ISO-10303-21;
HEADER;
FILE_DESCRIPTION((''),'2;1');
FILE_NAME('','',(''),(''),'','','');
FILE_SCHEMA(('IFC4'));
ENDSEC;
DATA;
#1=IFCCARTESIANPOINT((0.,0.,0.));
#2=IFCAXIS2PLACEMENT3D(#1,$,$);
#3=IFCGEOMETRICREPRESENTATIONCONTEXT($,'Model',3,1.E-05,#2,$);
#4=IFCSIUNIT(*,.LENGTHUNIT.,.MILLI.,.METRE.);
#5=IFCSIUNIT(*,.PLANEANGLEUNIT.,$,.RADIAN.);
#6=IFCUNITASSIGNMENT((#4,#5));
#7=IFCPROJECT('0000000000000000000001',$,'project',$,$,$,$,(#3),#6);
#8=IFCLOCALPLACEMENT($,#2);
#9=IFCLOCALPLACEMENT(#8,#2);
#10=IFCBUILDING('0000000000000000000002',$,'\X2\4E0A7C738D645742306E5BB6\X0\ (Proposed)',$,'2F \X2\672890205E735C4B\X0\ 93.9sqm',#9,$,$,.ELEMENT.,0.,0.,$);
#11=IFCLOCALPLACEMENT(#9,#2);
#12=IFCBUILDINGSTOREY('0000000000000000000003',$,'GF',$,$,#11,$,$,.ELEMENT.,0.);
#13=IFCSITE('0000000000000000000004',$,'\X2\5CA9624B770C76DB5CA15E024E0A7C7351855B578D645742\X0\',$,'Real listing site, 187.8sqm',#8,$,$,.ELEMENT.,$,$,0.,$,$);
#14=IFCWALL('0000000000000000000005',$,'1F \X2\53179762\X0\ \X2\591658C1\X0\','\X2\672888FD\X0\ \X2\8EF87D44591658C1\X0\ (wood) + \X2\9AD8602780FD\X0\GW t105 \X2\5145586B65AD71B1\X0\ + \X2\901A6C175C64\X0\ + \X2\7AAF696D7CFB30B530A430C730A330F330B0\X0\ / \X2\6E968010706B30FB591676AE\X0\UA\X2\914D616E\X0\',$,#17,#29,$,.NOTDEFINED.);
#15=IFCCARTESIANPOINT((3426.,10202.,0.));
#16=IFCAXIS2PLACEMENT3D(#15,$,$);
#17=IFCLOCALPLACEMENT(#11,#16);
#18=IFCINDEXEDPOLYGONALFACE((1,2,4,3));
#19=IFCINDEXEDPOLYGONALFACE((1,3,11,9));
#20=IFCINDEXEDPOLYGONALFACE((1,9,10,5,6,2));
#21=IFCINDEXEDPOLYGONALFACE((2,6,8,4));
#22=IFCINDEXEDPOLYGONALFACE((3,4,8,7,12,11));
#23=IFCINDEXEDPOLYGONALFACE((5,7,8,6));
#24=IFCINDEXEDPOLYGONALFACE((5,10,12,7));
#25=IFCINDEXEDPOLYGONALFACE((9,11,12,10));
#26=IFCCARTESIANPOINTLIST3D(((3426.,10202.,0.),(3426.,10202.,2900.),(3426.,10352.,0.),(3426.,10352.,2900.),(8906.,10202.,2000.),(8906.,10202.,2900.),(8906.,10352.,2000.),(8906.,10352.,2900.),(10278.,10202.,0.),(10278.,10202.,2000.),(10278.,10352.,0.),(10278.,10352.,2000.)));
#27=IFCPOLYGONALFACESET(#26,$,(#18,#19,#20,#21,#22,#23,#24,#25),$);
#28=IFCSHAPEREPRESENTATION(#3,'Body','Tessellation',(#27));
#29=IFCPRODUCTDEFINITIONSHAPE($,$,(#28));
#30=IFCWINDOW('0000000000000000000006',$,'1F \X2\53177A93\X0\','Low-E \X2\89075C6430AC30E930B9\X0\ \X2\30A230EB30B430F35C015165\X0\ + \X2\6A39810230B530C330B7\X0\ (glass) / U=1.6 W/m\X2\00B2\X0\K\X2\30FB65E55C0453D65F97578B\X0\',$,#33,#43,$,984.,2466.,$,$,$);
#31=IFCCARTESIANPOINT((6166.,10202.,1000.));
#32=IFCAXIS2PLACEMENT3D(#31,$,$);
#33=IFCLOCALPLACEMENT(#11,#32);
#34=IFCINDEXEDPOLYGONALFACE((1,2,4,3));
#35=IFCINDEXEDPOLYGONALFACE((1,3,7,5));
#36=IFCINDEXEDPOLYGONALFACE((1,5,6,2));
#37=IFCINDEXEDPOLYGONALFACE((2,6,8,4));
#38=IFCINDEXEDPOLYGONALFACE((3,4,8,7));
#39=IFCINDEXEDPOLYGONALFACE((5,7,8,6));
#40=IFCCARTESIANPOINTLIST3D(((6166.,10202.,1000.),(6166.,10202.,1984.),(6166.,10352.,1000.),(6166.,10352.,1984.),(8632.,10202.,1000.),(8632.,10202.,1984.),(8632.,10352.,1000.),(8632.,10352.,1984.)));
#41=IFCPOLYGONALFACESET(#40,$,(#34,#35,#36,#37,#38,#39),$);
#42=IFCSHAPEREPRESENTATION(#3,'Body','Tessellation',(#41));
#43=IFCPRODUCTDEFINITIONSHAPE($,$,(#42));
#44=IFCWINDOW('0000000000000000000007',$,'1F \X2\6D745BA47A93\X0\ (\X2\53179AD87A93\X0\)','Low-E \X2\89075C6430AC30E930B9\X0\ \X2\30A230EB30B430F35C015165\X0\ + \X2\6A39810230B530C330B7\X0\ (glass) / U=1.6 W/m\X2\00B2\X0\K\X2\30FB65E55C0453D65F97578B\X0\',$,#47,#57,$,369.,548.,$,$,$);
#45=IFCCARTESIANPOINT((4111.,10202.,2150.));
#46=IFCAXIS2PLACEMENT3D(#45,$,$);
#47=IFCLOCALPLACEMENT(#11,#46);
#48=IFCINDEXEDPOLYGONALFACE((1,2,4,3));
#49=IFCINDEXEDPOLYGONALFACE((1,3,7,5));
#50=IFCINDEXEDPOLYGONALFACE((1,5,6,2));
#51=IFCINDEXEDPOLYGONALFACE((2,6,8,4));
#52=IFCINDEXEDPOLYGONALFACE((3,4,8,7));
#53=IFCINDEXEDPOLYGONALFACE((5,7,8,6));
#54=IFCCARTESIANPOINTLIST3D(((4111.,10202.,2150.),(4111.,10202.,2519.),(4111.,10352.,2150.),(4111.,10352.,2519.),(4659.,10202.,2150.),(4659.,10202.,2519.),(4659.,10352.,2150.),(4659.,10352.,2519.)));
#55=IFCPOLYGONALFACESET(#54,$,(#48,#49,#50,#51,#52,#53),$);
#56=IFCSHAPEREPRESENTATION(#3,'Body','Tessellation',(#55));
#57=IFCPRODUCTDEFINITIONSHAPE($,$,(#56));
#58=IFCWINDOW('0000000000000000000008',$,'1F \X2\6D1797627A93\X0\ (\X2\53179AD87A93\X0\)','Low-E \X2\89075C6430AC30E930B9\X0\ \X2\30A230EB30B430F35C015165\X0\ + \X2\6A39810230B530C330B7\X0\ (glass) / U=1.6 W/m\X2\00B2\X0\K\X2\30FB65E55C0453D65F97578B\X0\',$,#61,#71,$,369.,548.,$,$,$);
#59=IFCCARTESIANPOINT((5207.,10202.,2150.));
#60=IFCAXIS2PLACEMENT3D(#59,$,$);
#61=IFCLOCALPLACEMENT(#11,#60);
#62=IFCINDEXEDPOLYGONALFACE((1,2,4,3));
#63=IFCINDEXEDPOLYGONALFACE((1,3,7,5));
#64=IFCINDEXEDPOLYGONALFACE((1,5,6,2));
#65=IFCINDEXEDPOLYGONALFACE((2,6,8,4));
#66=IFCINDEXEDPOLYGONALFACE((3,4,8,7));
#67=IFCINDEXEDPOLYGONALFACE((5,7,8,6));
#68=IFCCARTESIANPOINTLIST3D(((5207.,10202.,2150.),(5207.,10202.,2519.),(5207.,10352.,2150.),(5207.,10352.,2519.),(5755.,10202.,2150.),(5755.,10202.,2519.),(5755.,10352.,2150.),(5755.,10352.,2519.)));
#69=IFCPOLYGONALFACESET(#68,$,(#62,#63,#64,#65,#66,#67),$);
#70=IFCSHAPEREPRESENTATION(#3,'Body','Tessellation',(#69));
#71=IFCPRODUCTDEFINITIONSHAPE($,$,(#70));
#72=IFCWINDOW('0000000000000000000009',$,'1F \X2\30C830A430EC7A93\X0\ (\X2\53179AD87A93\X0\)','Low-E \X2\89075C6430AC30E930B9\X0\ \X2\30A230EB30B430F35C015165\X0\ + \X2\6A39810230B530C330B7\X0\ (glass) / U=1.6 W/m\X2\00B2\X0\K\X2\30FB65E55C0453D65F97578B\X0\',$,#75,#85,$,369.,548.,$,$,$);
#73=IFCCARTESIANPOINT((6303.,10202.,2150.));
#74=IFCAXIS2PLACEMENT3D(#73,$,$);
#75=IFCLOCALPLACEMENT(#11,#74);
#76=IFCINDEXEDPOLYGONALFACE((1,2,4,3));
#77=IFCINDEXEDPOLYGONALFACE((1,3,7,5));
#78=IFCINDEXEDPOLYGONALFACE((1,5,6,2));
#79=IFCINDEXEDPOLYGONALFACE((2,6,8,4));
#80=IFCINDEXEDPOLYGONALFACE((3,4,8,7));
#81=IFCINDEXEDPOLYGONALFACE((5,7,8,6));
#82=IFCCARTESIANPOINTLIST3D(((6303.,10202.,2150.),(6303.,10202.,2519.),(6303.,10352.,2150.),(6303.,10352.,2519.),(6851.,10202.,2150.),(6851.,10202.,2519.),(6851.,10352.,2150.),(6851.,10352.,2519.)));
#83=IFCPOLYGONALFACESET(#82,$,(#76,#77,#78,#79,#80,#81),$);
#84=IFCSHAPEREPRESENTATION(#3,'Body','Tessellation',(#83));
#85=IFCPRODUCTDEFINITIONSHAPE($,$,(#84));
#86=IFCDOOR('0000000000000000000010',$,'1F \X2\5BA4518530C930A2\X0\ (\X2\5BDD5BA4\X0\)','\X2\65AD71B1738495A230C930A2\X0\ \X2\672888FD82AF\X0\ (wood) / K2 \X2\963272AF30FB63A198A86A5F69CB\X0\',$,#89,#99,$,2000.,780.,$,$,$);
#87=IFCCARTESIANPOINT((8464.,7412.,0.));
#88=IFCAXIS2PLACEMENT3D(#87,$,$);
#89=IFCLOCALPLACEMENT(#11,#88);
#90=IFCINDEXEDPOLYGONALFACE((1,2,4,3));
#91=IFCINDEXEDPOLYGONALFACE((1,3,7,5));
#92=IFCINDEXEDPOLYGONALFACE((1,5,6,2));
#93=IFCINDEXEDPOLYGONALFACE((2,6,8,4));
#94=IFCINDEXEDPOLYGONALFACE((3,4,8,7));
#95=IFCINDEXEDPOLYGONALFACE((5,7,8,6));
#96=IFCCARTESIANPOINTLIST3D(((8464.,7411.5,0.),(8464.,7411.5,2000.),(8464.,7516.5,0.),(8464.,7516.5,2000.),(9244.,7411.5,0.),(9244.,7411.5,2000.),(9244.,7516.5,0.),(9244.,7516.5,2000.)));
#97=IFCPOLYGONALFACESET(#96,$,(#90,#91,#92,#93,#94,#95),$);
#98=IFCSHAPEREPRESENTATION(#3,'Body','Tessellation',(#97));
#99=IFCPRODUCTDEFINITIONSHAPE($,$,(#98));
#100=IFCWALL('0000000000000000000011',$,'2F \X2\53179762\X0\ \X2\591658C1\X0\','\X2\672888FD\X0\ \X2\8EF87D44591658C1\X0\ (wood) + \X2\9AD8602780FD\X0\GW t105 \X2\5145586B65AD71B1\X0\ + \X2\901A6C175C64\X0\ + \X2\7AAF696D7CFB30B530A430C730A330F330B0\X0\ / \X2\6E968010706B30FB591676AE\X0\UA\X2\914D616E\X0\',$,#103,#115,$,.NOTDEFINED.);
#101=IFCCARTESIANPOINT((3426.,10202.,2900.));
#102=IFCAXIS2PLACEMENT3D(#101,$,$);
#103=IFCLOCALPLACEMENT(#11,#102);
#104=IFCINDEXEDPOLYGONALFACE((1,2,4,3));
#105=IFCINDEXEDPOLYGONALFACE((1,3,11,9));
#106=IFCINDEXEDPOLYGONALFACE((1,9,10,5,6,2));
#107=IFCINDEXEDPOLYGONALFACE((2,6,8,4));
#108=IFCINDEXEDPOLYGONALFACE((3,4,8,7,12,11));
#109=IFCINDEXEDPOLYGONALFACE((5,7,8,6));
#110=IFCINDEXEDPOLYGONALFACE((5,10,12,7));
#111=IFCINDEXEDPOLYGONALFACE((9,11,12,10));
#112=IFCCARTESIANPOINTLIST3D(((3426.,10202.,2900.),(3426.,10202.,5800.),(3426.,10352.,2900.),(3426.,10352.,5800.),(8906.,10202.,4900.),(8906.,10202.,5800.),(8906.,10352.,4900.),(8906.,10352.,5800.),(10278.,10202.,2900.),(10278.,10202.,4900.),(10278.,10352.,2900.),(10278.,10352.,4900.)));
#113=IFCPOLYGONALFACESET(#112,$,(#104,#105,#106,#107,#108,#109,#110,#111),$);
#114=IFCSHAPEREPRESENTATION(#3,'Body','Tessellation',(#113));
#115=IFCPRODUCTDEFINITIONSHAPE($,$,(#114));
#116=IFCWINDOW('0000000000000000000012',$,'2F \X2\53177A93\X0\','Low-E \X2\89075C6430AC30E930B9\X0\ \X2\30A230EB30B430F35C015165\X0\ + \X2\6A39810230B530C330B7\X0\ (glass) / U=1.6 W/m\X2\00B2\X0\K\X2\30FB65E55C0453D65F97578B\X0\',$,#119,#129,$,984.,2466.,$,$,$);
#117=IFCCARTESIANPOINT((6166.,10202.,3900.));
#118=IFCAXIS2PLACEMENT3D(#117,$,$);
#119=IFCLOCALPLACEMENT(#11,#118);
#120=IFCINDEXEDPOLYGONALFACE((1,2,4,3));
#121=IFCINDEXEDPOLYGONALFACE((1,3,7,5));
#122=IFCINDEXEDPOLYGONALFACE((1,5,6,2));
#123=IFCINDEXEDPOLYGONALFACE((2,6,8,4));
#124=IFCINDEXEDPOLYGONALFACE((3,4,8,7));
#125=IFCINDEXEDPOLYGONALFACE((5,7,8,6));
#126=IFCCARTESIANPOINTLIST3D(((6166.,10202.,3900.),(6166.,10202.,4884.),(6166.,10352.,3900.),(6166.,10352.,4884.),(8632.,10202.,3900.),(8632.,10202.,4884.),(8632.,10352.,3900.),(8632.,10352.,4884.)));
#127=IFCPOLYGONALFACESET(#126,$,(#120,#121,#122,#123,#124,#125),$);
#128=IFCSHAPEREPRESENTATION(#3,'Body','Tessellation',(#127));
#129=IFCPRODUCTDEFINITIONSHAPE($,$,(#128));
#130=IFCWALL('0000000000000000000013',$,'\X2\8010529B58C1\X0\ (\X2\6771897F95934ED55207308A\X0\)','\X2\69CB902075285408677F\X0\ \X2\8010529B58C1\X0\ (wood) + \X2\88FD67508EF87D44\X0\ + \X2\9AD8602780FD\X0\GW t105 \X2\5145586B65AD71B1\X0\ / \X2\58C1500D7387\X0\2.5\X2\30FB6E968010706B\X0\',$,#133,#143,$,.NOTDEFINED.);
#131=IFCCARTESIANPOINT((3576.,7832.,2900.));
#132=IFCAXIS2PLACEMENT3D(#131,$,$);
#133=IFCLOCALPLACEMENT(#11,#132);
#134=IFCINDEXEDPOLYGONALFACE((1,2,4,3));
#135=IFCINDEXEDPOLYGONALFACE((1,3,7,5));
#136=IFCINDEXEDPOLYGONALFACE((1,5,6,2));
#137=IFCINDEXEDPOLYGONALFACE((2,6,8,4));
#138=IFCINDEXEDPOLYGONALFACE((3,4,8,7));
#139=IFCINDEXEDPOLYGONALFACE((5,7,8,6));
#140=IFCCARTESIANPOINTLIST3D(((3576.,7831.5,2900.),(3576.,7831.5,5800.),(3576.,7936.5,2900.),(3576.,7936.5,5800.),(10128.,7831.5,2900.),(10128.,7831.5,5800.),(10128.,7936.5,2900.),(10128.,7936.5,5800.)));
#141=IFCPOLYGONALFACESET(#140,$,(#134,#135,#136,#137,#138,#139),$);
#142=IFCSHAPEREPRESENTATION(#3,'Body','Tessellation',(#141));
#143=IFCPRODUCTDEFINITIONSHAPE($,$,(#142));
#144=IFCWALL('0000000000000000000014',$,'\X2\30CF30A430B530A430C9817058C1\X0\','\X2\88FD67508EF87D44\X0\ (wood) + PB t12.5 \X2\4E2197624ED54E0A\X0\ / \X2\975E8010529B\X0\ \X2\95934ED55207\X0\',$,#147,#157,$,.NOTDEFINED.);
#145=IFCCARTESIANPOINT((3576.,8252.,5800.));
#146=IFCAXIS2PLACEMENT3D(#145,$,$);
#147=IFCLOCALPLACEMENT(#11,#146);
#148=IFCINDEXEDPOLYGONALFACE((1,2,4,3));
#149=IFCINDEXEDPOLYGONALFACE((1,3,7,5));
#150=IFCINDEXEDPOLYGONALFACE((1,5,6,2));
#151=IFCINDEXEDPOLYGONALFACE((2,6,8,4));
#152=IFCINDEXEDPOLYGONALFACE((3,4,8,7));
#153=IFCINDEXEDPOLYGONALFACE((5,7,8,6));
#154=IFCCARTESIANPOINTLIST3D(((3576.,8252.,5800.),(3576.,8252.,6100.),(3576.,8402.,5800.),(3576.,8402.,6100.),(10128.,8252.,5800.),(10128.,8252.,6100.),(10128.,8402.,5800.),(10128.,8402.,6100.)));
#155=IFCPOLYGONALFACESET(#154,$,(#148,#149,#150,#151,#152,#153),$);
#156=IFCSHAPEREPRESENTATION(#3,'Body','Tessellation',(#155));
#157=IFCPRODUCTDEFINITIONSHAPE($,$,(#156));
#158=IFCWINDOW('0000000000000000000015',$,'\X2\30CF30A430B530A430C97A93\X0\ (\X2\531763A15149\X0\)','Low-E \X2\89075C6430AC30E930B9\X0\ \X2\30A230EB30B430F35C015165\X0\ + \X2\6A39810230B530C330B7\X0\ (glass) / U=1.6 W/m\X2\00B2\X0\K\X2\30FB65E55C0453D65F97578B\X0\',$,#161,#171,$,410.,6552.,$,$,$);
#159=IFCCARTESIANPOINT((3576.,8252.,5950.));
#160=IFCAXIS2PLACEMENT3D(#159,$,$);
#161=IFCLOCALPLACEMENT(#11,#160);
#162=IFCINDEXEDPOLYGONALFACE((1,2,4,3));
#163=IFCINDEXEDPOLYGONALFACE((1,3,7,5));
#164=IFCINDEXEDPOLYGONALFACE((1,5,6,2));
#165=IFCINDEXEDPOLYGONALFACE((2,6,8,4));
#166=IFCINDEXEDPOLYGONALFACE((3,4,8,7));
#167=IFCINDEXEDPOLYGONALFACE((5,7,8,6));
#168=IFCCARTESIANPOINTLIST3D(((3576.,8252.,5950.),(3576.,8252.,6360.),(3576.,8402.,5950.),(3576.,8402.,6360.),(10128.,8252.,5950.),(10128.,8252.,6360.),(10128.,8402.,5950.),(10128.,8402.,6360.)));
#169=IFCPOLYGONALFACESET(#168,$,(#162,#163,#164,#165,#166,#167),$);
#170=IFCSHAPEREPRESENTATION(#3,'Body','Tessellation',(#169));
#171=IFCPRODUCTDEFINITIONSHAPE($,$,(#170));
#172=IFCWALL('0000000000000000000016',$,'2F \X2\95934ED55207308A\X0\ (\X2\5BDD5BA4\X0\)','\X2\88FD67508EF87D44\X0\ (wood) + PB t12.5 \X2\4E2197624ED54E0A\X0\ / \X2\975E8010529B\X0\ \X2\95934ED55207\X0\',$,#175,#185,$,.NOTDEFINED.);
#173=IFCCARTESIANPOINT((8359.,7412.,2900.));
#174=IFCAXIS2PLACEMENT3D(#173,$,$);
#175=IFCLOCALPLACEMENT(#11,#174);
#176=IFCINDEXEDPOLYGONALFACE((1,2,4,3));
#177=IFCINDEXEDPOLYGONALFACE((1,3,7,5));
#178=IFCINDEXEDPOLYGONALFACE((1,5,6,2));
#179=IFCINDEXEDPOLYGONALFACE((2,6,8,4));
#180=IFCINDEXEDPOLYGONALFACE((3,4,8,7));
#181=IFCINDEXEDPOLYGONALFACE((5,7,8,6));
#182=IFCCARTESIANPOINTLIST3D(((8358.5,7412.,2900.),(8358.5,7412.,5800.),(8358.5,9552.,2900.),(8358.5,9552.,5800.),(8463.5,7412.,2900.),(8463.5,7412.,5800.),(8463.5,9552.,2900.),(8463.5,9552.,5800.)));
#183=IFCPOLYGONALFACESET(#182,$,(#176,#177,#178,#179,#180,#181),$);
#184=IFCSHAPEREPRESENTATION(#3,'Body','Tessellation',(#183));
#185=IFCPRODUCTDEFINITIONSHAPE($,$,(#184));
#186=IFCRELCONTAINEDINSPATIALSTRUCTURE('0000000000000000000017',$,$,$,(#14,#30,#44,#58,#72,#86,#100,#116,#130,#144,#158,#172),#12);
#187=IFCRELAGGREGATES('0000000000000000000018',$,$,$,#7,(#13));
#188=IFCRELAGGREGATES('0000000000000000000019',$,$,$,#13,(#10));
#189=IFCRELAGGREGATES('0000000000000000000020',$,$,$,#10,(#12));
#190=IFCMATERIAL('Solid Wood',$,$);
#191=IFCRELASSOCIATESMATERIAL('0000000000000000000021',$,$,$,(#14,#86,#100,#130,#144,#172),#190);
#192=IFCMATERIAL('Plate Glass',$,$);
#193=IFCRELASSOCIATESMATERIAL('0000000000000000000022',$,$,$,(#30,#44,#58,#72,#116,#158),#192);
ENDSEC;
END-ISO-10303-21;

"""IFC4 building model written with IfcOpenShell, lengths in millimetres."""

from ifc_helpers import new_model, si_unit, frame, frame_2d, origin, place, context, project, spatial, rectangle, extrude, material, element, fill, save


model = new_model("IFC4")

# Units and contexts
model_context = context("Model", 3, precision=1e-05, world=origin())
ifc_project = project(units=[si_unit("LENGTHUNIT", "METRE", prefix="MILLI"), si_unit("PLANEANGLEUNIT", "RADIAN")], contexts=[model_context])

# Site, building, storey
site_placement = place(None, origin())
site = spatial("IfcSite", under=ifc_project, at=site_placement, Name="岩手県盛岡市上米内字赤坂", ObjectType="Real listing site, 187.8sqm", CompositionType="ELEMENT", RefElevation=0.0)
building_placement = place(site_placement, origin())
building = spatial("IfcBuilding", under=site, at=building_placement, Name="上米赤坂の家 (Proposed)", ObjectType="2F 木造平屋 93.9sqm", CompositionType="ELEMENT", ElevationOfRefHeight=0.0, ElevationOfTerrain=0.0)
storey_placement = place(building_placement, origin())
storey = spatial("IfcBuildingStorey", under=building, at=storey_placement, Name="GF", CompositionType="ELEMENT", Elevation=0.0)

# Wall, openings, windows
ifc_material_1 = material(Name="Solid Wood")
wall_1_placement = place(storey_placement, frame((3426.0, 10202.0, 0.0)))
wall_1 = element("IfcWall", 1, at=wall_1_placement, inside=storey, material=ifc_material_1, Name="1F 北面 外壁", Description="木製 軸組外壁 (wood) + 高性能GW t105 充填断熱 + 通気層 + 窯業系サイディング / 準耐火・外皮UA配慮", PredefinedType="NOTDEFINED", context=model_context, shape_type="SweptSolid", body=[
    extrude(rectangle(XDim=6852.0, YDim=150.0, at=frame_2d((3426.0, 75.0))), frame((3426.0, 10202.0, 0.0)), (0.0, 0.0, 1.0), 2900.0),
])
opening_1_placement = place(storey_placement, frame((6166.0, 10202.0, 1000.0)))
opening_1 = element("IfcOpeningElement", 2, at=opening_1_placement, cuts=wall_1, PredefinedType="NOTDEFINED", context=model_context, shape_type="SweptSolid", body=[
    extrude(rectangle(XDim=2466.0, YDim=150.0, at=frame_2d((1233.0, 75.0))), frame((6166.0, 10202.0, 1000.0)), (0.0, 0.0, 1.0), 984.0),
])
opening_2_placement = place(storey_placement, frame((4111.0, 10202.0, 2150.0)))
opening_2 = element("IfcOpeningElement", 3, at=opening_2_placement, cuts=wall_1, PredefinedType="NOTDEFINED", context=model_context, shape_type="SweptSolid", body=[
    extrude(rectangle(XDim=548.0, YDim=150.0, at=frame_2d((274.0, 75.0))), frame((4111.0, 10202.0, 2150.0)), (0.0, 0.0, 1.0), 369.0),
])
opening_3_placement = place(storey_placement, frame((5207.0, 10202.0, 2150.0)))
opening_3 = element("IfcOpeningElement", 4, at=opening_3_placement, cuts=wall_1, PredefinedType="NOTDEFINED", context=model_context, shape_type="SweptSolid", body=[
    extrude(rectangle(XDim=548.0, YDim=150.0, at=frame_2d((274.0, 75.0))), frame((5207.0, 10202.0, 2150.0)), (0.0, 0.0, 1.0), 369.0),
])
opening_4_placement = place(storey_placement, frame((6303.0, 10202.0, 2150.0)))
opening_4 = element("IfcOpeningElement", 5, at=opening_4_placement, cuts=wall_1, PredefinedType="NOTDEFINED", context=model_context, shape_type="SweptSolid", body=[
    extrude(rectangle(XDim=548.0, YDim=150.0, at=frame_2d((274.0, 75.0))), frame((6303.0, 10202.0, 2150.0)), (0.0, 0.0, 1.0), 369.0),
])
ifc_material_2 = material(Name="Plate Glass")
window_1_placement = place(storey_placement, frame((6166.0, 10202.0, 1000.0)))
window_1 = element("IfcWindow", 6, at=window_1_placement, inside=storey, material=ifc_material_2, Name="1F 北窓", Description="Low-E 複層ガラス アルゴン封入 + 樹脂サッシ (glass) / U=1.6 W/m²K・日射取得型", OverallHeight=984.0, OverallWidth=2466.0, context=model_context, shape_type="SweptSolid", body=[
    extrude(rectangle(XDim=2466.0, YDim=150.0, at=frame_2d((1233.0, 75.0))), frame((6166.0, 10202.0, 1000.0)), (0.0, 0.0, 1.0), 984.0),
])
fill(opening_1, window_1)
window_2_placement = place(storey_placement, frame((4111.0, 10202.0, 2150.0)))
window_2 = element("IfcWindow", 7, at=window_2_placement, inside=storey, material=ifc_material_2, Name="1F 浴室窓 (北高窓)", Description="Low-E 複層ガラス アルゴン封入 + 樹脂サッシ (glass) / U=1.6 W/m²K・日射取得型", OverallHeight=369.0, OverallWidth=548.0, context=model_context, shape_type="SweptSolid", body=[
    extrude(rectangle(XDim=548.0, YDim=150.0, at=frame_2d((274.0, 75.0))), frame((4111.0, 10202.0, 2150.0)), (0.0, 0.0, 1.0), 369.0),
])
fill(opening_2, window_2)
window_3_placement = place(storey_placement, frame((5207.0, 10202.0, 2150.0)))
window_3 = element("IfcWindow", 8, at=window_3_placement, inside=storey, material=ifc_material_2, Name="1F 洗面窓 (北高窓)", Description="Low-E 複層ガラス アルゴン封入 + 樹脂サッシ (glass) / U=1.6 W/m²K・日射取得型", OverallHeight=369.0, OverallWidth=548.0, context=model_context, shape_type="SweptSolid", body=[
    extrude(rectangle(XDim=548.0, YDim=150.0, at=frame_2d((274.0, 75.0))), frame((5207.0, 10202.0, 2150.0)), (0.0, 0.0, 1.0), 369.0),
])
fill(opening_3, window_3)
window_4_placement = place(storey_placement, frame((6303.0, 10202.0, 2150.0)))
window_4 = element("IfcWindow", 9, at=window_4_placement, inside=storey, material=ifc_material_2, Name="1F トイレ窓 (北高窓)", Description="Low-E 複層ガラス アルゴン封入 + 樹脂サッシ (glass) / U=1.6 W/m²K・日射取得型", OverallHeight=369.0, OverallWidth=548.0, context=model_context, shape_type="SweptSolid", body=[
    extrude(rectangle(XDim=548.0, YDim=150.0, at=frame_2d((274.0, 75.0))), frame((6303.0, 10202.0, 2150.0)), (0.0, 0.0, 1.0), 369.0),
])
fill(opening_4, window_4)

# Door
door_1_placement = place(storey_placement, frame((8464.0, 7412.0, 0.0)))
element("IfcDoor", 10, at=door_1_placement, inside=storey, material=ifc_material_1, Name="1F 室内ドア (寝室)", Description="断熱玄関ドア 木製芯 (wood) / K2 防犯・採風機構", OverallHeight=2000.0, OverallWidth=780.0, context=model_context, shape_type="SweptSolid", body=[
    extrude(rectangle(XDim=780.0, YDim=105.0, at=frame_2d((390.0, 52.0))), frame((8464.0, 7412.0, 0.0)), (0.0, 0.0, 1.0), 2000.0),
])

# Wall, opening, window
wall_2_placement = place(storey_placement, frame((3426.0, 10202.0, 2900.0)))
wall_2 = element("IfcWall", 11, at=wall_2_placement, inside=storey, material=ifc_material_1, Name="2F 北面 外壁", Description="木製 軸組外壁 (wood) + 高性能GW t105 充填断熱 + 通気層 + 窯業系サイディング / 準耐火・外皮UA配慮", PredefinedType="NOTDEFINED", context=model_context, shape_type="SweptSolid", body=[
    extrude(rectangle(XDim=6852.0, YDim=150.0, at=frame_2d((3426.0, 75.0))), frame((3426.0, 10202.0, 2900.0)), (0.0, 0.0, 1.0), 2900.0),
])
opening_5_placement = place(storey_placement, frame((6166.0, 10202.0, 3900.0)))
opening_5 = element("IfcOpeningElement", 12, at=opening_5_placement, cuts=wall_2, PredefinedType="NOTDEFINED", context=model_context, shape_type="SweptSolid", body=[
    extrude(rectangle(XDim=2466.0, YDim=150.0, at=frame_2d((1233.0, 75.0))), frame((6166.0, 10202.0, 3900.0)), (0.0, 0.0, 1.0), 984.0),
])
window_5_placement = place(storey_placement, frame((6166.0, 10202.0, 3900.0)))
window_5 = element("IfcWindow", 13, at=window_5_placement, inside=storey, material=ifc_material_2, Name="2F 北窓", Description="Low-E 複層ガラス アルゴン封入 + 樹脂サッシ (glass) / U=1.6 W/m²K・日射取得型", OverallHeight=984.0, OverallWidth=2466.0, context=model_context, shape_type="SweptSolid", body=[
    extrude(rectangle(XDim=2466.0, YDim=150.0, at=frame_2d((1233.0, 75.0))), frame((6166.0, 10202.0, 3900.0)), (0.0, 0.0, 1.0), 984.0),
])
fill(opening_5, window_5)

# Wall
wall_3_placement = place(storey_placement, frame((3576.0, 7832.0, 2900.0)))
element("IfcWall", 14, at=wall_3_placement, inside=storey, material=ifc_material_1, Name="耐力壁 (東西間仕切り)", Description="構造用合板 耐力壁 (wood) + 製材軸組 + 高性能GW t105 充填断熱 / 壁倍率2.5・準耐火", PredefinedType="NOTDEFINED", context=model_context, shape_type="SweptSolid", body=[
    extrude(rectangle(XDim=6552.0, YDim=105.0, at=frame_2d((3276.0, 52.0))), frame((3576.0, 7832.0, 2900.0)), (0.0, 0.0, 1.0), 2900.0),
])

# Wall, opening, window
wall_4_placement = place(storey_placement, frame((3576.0, 8252.0, 5800.0)))
wall_4 = element("IfcWall", 15, at=wall_4_placement, inside=storey, material=ifc_material_1, Name="ハイサイド腰壁", Description="製材軸組 (wood) + PB t12.5 両面仕上 / 非耐力 間仕切", PredefinedType="NOTDEFINED", context=model_context, shape_type="SweptSolid", body=[
    extrude(rectangle(XDim=6552.0, YDim=150.0, at=frame_2d((3276.0, 75.0))), frame((3576.0, 8252.0, 5800.0)), (0.0, 0.0, 1.0), 700.0),
])
opening_6_placement = place(storey_placement, frame((3576.0, 8252.0, 5950.0)))
opening_6 = element("IfcOpeningElement", 16, at=opening_6_placement, cuts=wall_4, PredefinedType="NOTDEFINED", context=model_context, shape_type="SweptSolid", body=[
    extrude(rectangle(XDim=6552.0, YDim=150.0, at=frame_2d((3276.0, 75.0))), frame((3576.0, 8252.0, 5950.0)), (0.0, 0.0, 1.0), 410.0),
])
window_6_placement = place(storey_placement, frame((3576.0, 8252.0, 5950.0)))
window_6 = element("IfcWindow", 17, at=window_6_placement, inside=storey, material=ifc_material_2, Name="ハイサイド窓 (北採光)", Description="Low-E 複層ガラス アルゴン封入 + 樹脂サッシ (glass) / U=1.6 W/m²K・日射取得型", OverallHeight=410.0, OverallWidth=6552.0, context=model_context, shape_type="SweptSolid", body=[
    extrude(rectangle(XDim=6552.0, YDim=150.0, at=frame_2d((3276.0, 75.0))), frame((3576.0, 8252.0, 5950.0)), (0.0, 0.0, 1.0), 410.0),
])
fill(opening_6, window_6)

# Wall
wall_5_placement = place(storey_placement, frame((8359.0, 7412.0, 2900.0)))
element("IfcWall", 18, at=wall_5_placement, inside=storey, material=ifc_material_1, Name="2F 間仕切り (寝室)", Description="製材軸組 (wood) + PB t12.5 両面仕上 / 非耐力 間仕切", PredefinedType="NOTDEFINED", context=model_context, shape_type="SweptSolid", body=[
    extrude(rectangle(XDim=105.0, YDim=2140.0, at=frame_2d((52.0, 1070.0))), frame((8359.0, 7412.0, 2900.0)), (0.0, 0.0, 1.0), 2900.0),
])

save(model, "model.ifc")
